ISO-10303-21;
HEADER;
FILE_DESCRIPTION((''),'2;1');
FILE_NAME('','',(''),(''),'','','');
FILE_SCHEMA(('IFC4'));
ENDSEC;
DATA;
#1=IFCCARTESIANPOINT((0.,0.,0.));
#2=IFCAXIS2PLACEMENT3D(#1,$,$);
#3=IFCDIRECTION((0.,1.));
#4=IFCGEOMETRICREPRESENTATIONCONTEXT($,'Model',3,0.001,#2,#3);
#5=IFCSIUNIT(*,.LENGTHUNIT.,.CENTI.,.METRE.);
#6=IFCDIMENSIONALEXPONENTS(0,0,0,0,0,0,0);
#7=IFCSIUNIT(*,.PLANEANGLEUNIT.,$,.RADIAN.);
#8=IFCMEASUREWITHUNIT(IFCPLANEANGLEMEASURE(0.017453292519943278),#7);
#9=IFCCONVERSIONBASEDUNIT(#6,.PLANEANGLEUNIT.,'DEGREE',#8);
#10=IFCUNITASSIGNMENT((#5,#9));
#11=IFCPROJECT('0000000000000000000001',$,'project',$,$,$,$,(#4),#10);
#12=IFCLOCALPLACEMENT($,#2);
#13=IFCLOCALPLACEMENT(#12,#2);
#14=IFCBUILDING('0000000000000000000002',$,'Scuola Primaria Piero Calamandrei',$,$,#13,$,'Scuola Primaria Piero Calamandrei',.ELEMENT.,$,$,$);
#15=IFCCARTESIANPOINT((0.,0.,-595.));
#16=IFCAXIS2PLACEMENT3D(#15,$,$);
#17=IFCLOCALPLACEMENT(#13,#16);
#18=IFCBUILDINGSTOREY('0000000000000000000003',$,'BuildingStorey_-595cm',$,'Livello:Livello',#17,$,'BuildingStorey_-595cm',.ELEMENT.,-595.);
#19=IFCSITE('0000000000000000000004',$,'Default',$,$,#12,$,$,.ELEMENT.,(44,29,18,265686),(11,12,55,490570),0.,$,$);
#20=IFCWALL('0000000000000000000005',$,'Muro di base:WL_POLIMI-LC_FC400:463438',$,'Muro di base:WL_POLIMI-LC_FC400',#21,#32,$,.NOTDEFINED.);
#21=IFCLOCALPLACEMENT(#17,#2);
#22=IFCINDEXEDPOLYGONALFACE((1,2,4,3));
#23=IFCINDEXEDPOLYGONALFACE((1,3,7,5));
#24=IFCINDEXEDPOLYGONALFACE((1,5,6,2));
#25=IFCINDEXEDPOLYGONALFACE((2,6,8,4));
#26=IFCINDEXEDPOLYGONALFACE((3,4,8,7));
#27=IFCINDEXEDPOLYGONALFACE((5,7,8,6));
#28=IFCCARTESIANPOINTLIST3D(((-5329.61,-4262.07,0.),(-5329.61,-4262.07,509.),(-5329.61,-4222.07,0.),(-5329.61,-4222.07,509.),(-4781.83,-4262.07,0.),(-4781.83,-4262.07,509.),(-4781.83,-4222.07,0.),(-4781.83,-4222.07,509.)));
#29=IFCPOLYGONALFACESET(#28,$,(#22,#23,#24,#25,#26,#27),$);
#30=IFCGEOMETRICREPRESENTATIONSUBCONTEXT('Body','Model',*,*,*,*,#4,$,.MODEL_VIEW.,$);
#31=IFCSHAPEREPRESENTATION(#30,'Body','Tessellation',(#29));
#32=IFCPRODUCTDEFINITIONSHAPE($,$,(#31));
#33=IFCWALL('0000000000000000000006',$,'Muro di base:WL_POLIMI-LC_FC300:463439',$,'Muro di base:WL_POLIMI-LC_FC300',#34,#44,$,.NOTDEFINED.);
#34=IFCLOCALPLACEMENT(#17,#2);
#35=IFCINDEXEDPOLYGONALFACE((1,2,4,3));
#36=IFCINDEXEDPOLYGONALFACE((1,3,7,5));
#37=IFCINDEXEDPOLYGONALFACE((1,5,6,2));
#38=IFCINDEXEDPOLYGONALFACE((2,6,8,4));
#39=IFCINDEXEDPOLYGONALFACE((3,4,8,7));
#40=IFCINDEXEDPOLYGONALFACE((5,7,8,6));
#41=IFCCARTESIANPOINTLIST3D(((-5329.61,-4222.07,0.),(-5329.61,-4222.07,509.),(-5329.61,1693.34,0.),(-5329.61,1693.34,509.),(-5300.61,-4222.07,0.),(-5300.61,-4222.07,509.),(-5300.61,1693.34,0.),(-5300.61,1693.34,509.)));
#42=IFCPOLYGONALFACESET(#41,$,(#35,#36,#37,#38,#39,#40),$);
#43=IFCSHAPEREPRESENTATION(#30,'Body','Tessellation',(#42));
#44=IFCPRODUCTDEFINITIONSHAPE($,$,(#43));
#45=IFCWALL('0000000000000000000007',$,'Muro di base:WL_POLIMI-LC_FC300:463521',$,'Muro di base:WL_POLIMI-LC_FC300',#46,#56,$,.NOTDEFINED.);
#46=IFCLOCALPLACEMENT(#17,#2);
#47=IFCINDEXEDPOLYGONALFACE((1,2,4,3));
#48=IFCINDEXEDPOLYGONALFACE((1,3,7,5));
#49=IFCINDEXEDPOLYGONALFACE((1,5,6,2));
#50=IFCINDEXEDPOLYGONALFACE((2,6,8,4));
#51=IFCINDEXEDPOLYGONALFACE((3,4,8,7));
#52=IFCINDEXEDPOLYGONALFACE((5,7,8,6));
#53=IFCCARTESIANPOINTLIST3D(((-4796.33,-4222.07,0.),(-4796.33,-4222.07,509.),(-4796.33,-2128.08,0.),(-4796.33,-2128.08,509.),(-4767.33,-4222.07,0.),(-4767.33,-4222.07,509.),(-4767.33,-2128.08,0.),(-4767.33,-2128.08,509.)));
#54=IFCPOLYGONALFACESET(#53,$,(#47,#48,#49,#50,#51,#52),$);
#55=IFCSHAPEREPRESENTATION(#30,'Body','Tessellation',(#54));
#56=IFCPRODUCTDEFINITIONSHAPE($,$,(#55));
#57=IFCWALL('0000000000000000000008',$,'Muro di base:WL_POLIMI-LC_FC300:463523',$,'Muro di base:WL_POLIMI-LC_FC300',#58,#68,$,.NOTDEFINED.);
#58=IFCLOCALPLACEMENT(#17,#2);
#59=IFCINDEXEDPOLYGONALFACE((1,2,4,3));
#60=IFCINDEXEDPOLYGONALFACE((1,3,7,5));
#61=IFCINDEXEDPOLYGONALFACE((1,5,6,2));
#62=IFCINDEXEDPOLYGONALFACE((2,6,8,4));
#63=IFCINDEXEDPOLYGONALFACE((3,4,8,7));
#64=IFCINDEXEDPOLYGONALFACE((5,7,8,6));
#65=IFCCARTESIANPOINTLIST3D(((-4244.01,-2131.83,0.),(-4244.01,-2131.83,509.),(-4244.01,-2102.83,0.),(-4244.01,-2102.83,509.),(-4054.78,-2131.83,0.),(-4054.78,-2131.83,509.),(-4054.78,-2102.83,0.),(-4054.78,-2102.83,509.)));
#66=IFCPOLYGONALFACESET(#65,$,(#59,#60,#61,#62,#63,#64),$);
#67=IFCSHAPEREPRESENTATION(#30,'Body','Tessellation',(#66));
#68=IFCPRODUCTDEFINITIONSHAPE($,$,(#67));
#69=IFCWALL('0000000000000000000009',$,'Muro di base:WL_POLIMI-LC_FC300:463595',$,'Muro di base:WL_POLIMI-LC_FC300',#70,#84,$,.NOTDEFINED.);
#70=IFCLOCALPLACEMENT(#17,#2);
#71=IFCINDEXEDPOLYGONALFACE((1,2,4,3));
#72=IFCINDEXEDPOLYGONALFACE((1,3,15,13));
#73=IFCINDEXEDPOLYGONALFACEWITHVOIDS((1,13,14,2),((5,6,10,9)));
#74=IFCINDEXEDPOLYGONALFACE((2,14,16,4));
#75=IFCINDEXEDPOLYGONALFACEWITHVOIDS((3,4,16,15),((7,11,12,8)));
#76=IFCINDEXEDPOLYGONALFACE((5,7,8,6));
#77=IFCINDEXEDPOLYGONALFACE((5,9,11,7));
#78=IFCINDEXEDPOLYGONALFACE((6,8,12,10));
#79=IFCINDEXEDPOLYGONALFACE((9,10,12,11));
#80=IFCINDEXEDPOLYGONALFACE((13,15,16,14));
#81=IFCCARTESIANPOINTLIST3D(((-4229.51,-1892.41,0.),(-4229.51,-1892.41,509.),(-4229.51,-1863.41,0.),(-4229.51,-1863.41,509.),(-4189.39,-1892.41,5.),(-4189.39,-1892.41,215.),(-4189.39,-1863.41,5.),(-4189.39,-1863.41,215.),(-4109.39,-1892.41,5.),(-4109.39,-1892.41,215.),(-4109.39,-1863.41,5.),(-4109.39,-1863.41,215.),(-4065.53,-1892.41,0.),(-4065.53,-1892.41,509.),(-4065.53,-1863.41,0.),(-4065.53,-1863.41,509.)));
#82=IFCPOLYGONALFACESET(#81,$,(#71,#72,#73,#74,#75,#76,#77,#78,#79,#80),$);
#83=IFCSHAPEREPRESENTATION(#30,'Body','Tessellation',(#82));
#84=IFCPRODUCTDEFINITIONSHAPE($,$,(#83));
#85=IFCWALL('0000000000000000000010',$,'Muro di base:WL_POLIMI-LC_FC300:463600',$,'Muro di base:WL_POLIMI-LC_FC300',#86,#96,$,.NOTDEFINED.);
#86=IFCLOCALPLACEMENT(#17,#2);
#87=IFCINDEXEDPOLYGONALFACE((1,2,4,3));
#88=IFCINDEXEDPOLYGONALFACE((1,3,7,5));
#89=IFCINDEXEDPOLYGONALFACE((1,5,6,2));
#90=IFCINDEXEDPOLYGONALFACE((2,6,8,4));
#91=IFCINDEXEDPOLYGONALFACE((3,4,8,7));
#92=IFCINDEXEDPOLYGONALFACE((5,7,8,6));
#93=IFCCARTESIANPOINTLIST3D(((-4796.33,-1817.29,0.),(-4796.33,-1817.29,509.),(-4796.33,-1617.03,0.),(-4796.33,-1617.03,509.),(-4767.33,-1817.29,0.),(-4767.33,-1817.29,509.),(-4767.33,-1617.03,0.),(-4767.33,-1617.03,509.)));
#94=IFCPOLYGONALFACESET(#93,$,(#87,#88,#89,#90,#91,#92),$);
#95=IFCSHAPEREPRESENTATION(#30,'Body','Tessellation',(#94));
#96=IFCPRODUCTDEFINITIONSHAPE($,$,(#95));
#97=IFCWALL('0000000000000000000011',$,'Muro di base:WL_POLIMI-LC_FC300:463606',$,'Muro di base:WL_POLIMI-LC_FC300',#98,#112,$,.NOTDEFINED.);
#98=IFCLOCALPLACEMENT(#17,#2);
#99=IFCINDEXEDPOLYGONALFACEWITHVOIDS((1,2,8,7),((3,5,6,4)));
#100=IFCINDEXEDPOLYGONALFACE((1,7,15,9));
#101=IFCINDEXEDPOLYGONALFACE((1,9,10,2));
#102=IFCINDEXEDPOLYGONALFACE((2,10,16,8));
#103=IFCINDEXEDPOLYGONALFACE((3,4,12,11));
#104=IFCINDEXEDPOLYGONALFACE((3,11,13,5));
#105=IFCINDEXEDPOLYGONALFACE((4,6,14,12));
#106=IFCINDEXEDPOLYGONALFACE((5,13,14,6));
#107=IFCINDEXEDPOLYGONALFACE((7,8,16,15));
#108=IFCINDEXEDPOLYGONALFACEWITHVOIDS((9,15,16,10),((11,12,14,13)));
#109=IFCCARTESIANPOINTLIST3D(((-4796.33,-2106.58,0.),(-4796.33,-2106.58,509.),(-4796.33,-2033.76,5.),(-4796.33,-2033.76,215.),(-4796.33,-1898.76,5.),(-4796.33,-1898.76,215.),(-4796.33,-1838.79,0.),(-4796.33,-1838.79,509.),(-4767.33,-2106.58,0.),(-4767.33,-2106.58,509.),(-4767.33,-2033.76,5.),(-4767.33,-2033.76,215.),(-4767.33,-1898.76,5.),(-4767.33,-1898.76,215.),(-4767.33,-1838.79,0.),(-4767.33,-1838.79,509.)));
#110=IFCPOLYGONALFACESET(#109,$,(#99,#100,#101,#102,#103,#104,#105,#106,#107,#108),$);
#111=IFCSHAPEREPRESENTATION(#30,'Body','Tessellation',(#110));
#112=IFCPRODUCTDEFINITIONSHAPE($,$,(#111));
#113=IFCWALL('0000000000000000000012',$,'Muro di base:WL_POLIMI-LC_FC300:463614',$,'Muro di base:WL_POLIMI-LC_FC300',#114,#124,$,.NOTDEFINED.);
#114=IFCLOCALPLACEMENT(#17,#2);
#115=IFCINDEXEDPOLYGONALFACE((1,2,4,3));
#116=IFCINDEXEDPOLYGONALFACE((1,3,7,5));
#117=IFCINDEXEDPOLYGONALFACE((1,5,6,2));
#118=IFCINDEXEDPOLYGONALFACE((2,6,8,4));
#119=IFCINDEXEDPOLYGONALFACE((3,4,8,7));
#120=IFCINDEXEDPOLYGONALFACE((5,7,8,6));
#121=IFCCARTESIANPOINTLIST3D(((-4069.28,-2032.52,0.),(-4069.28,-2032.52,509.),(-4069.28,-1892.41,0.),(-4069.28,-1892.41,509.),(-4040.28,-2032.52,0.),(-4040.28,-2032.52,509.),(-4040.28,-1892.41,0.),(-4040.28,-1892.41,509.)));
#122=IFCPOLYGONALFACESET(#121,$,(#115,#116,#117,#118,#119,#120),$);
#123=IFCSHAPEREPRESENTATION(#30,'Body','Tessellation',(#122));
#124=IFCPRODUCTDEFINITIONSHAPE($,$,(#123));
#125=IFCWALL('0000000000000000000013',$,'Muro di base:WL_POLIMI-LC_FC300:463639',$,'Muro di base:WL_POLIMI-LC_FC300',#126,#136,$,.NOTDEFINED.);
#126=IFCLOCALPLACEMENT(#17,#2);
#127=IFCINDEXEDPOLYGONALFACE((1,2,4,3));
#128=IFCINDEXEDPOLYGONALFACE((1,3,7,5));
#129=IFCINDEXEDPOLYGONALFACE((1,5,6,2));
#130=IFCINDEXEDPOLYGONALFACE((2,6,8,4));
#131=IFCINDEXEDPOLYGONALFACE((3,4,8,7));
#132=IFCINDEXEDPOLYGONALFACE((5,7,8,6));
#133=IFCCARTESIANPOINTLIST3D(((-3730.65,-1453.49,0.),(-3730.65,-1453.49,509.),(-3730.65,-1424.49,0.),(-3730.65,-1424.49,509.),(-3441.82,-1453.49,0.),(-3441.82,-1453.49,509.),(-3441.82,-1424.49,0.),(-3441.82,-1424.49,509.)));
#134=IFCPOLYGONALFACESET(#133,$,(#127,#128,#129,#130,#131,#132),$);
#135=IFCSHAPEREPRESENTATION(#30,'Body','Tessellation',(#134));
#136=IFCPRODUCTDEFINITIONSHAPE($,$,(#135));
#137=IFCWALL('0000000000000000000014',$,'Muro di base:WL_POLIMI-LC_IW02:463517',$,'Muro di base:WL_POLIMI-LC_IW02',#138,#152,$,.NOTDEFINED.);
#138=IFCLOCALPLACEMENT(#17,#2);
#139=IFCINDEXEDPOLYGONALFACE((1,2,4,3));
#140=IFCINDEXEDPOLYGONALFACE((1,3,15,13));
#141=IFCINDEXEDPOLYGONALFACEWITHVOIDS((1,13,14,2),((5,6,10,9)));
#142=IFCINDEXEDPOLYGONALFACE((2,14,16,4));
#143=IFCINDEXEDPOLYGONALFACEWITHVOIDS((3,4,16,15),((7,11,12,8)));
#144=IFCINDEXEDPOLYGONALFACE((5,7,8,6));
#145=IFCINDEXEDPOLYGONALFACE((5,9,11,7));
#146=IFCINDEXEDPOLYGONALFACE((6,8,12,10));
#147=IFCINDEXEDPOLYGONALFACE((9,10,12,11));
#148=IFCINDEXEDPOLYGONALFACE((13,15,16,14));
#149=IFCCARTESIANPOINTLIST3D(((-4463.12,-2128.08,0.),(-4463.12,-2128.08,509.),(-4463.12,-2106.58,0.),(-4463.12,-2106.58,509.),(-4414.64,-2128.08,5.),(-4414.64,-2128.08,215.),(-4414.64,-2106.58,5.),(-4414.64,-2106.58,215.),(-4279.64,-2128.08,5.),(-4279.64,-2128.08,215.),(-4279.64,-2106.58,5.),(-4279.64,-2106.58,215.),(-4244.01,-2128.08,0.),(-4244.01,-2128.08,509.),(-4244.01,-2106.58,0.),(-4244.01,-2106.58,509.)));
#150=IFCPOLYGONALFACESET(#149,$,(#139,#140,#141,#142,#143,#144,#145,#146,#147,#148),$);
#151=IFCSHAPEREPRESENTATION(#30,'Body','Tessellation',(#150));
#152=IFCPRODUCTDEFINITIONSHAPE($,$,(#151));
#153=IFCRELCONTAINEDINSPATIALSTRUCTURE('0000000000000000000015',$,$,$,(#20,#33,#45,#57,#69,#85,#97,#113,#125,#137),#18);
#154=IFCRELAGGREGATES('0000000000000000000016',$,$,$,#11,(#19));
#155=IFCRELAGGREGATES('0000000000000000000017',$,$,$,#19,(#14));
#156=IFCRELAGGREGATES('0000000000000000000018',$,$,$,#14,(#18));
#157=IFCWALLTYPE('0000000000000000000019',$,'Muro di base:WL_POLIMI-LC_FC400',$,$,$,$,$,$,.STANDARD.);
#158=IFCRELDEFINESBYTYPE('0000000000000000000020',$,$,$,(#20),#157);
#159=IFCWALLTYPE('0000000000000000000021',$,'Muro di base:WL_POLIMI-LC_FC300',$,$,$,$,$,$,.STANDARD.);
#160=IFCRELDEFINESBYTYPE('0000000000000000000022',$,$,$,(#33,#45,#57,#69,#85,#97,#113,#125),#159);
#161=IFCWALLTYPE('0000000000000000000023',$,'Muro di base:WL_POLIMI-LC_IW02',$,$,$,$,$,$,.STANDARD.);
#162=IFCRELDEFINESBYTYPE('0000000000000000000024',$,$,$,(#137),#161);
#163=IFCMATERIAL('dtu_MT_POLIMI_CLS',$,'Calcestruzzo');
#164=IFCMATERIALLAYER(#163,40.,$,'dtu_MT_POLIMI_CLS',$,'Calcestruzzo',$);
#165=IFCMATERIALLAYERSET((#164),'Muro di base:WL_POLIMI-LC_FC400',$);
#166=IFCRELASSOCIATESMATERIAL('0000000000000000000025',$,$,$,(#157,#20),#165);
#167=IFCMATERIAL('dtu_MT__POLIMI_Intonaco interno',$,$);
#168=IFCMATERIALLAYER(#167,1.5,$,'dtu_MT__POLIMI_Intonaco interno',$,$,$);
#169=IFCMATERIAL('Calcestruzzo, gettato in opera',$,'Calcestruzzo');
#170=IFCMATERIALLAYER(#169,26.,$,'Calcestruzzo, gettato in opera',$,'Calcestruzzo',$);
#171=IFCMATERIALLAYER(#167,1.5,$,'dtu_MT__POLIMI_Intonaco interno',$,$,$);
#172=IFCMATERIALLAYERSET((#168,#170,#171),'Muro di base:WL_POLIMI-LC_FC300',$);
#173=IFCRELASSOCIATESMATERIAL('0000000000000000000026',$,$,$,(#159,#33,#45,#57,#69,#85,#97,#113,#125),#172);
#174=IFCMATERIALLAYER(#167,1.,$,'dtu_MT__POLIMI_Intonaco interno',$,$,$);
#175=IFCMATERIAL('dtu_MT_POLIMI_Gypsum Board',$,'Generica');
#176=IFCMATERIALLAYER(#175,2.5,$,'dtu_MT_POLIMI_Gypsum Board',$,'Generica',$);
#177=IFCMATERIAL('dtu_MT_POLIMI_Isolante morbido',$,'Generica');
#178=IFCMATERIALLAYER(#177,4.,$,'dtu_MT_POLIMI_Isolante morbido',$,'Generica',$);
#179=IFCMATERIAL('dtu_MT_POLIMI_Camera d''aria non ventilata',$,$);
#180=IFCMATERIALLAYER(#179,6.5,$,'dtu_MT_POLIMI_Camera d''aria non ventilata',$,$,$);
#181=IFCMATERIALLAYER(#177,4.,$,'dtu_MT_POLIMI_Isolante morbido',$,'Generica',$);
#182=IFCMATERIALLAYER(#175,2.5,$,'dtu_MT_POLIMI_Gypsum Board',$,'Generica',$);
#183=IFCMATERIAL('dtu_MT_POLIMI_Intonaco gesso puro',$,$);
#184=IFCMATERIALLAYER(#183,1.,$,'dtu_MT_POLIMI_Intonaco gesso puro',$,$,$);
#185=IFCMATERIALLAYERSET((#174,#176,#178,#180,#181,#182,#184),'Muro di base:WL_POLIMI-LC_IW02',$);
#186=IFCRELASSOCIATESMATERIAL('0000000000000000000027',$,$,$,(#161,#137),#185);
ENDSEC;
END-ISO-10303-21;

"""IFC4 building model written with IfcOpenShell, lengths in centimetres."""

from ifc_helpers import new_model, entity, si_unit, converted_unit, direction, frame, frame_2d, origin, place, context, subcontext, project, spatial, polyline, rectangle, extrude, clip, bounded_halfspace, material, layer, layer_set, layer_usage, type_object, element, save


model = new_model("IFC4")

# Units and contexts
model_context = context("Model", 3, precision=0.001, world=origin(), true_north=direction((0.0, 1.0)))
body_context = subcontext(model_context, "Body", "Model", "MODEL_VIEW")
ifc_project = project(units=[si_unit("LENGTHUNIT", "METRE", prefix="CENTI"), converted_unit("PLANEANGLEUNIT", "DEGREE", entity("IfcPlaneAngleMeasure", 0.017453292519943278), si_unit("PLANEANGLEUNIT", "RADIAN"), dimensions=[0, 0, 0, 0, 0, 0, 0])], contexts=[model_context])

# Site, building, storey
site_placement = place(None, origin())
site = spatial("IfcSite", under=ifc_project, at=site_placement, Name="Default", CompositionType="ELEMENT", RefLatitude=(44, 29, 18, 265686), RefLongitude=(11, 12, 55, 490570), RefElevation=0.0)
building_placement = place(site_placement, origin())
building = spatial("IfcBuilding", under=site, at=building_placement, Name="Scuola Primaria Piero Calamandrei", LongName="Scuola Primaria Piero Calamandrei", CompositionType="ELEMENT")
storey_placement = place(building_placement, frame((0.0, 0.0, -595.0)))
storey = spatial("IfcBuildingStorey", under=building, at=storey_placement, Name="BuildingStorey_-595cm", ObjectType="Livello:Livello", LongName="BuildingStorey_-595cm", CompositionType="ELEMENT", Elevation=-595.0)

# Walls
ifc_material_1 = material(Name="dtu_MT_POLIMI_CLS", Category="Calcestruzzo")
ifc_layer_1 = layer(ifc_material_1, 40.0, Name="dtu_MT_POLIMI_CLS", Category="Calcestruzzo")
ifc_layer_set_1 = layer_set([ifc_layer_1], Name="Muro di base:WL_POLIMI-LC_FC400")
ifc_layer_usage_1 = layer_usage(ifc_layer_set_1, "AXIS2", "NEGATIVE", 20.0)
wall_type_1 = type_object("IfcWallType", Name="Muro di base:WL_POLIMI-LC_FC400", PredefinedType="STANDARD", material=ifc_layer_set_1)
wall_1_placement = place(storey_placement, frame((-4781.83, -4242.07, 0.0), z_axis=(0.0, 0.0, 1.0), x_axis=(-1.0, 0.0, 0.0)))
element("IfcWall", 1, at=wall_1_placement, inside=storey, type_object=wall_type_1, material=ifc_layer_usage_1, Name="Muro di base:WL_POLIMI-LC_FC400:463438", ObjectType="Muro di base:WL_POLIMI-LC_FC400", PredefinedType="NOTDEFINED", context=body_context, shape_type="Clipping", body=[
    clip(extrude(rectangle(XDim=547.78, YDim=40.0, at=frame_2d((273.89, 0.0), x_axis=(-1.0, 0.0))), origin(), (0.0, 0.0, 1.0), 509.0), bounded_halfspace(frame((0.0, -20.0, 509.0), z_axis=(0.0, 0.0, 1.0), x_axis=(-1.0, 0.0, 0.0)), False, frame((0.0, -20.0, 509.0)), polyline([(0.0, 0.0), (14.5, 0.0), (518.78, 0.0), (547.78, 0.0), (547.78, 40.0), (0.0, 40.0), (0.0, 0.0)]))),
])
ifc_material_2 = material(Name="dtu_MT__POLIMI_Intonaco interno")
ifc_layer_2 = layer(ifc_material_2, 1.5, Name="dtu_MT__POLIMI_Intonaco interno")
ifc_material_3 = material(Name="Calcestruzzo, gettato in opera", Category="Calcestruzzo")
ifc_layer_3 = layer(ifc_material_3, 26.0, Name="Calcestruzzo, gettato in opera", Category="Calcestruzzo")
ifc_layer_4 = layer(ifc_material_2, 1.5, Name="dtu_MT__POLIMI_Intonaco interno")
ifc_layer_set_2 = layer_set([ifc_layer_2, ifc_layer_3, ifc_layer_4], Name="Muro di base:WL_POLIMI-LC_FC300")
ifc_layer_usage_2 = layer_usage(ifc_layer_set_2, "AXIS2", "NEGATIVE", 14.5)
wall_type_2 = type_object("IfcWallType", Name="Muro di base:WL_POLIMI-LC_FC300", PredefinedType="STANDARD", material=ifc_layer_set_2)
wall_2_placement = place(storey_placement, frame((-5315.11, -4222.07, 0.0), z_axis=(0.0, 0.0, 1.0), x_axis=(0.0, 1.0, 0.0)))
element("IfcWall", 2, at=wall_2_placement, inside=storey, type_object=wall_type_2, material=ifc_layer_usage_2, Name="Muro di base:WL_POLIMI-LC_FC300:463439", ObjectType="Muro di base:WL_POLIMI-LC_FC300", PredefinedType="NOTDEFINED", context=body_context, shape_type="Clipping", body=[
    clip(extrude(rectangle(XDim=5915.41, YDim=29.0, at=frame_2d((2957.7, 0.0), x_axis=(-1.0, 0.0))), origin(), (0.0, 0.0, 1.0), 509.0), bounded_halfspace(frame((0.0, -14.5, 509.0), z_axis=(0.0, 0.0, 1.0), x_axis=(0.0, -1.0, 0.0)), False, frame((0.0, -14.5, 509.0)), polyline([(0.0, 0.0), (5900.91, 0.0), (5915.41, 0.0), (5915.41, 29.0), (0.0, 29.0), (0.0, 0.0)]))),
])
ifc_layer_usage_3 = layer_usage(ifc_layer_set_2, "AXIS2", "NEGATIVE", 14.5)
wall_3_placement = place(storey_placement, frame((-4781.83, -4222.07, 0.0), z_axis=(0.0, 0.0, 1.0), x_axis=(0.0, 1.0, 0.0)))
element("IfcWall", 3, at=wall_3_placement, inside=storey, type_object=wall_type_2, material=ifc_layer_usage_3, Name="Muro di base:WL_POLIMI-LC_FC300:463521", ObjectType="Muro di base:WL_POLIMI-LC_FC300", PredefinedType="NOTDEFINED", context=body_context, shape_type="SweptSolid", body=[
    extrude(rectangle(XDim=2093.99, YDim=29.0, at=frame_2d((1047.0, 0.0), x_axis=(-1.0, 0.0))), origin(), (0.0, 0.0, 1.0), 509.0),
])
ifc_layer_usage_4 = layer_usage(ifc_layer_set_2, "AXIS2", "NEGATIVE", 14.5)
wall_4_placement = place(storey_placement, frame((-4244.01, -2117.33, 0.0)))
element("IfcWall", 4, at=wall_4_placement, inside=storey, type_object=wall_type_2, material=ifc_layer_usage_4, Name="Muro di base:WL_POLIMI-LC_FC300:463523", ObjectType="Muro di base:WL_POLIMI-LC_FC300", PredefinedType="NOTDEFINED", context=body_context, shape_type="SweptSolid", body=[
    extrude(rectangle(XDim=189.23, YDim=29.0, at=frame_2d((94.62, 0.0), x_axis=(-1.0, 0.0))), origin(), (0.0, 0.0, 1.0), 509.0),
])

# Wall, opening
ifc_layer_usage_5 = layer_usage(ifc_layer_set_2, "AXIS2", "NEGATIVE", 14.5)
wall_5_placement = place(storey_placement, frame((-4065.53, -1877.91, 0.0), z_axis=(0.0, 0.0, 1.0), x_axis=(-1.0, 0.0, 0.0)))
wall_5 = element("IfcWall", 5, at=wall_5_placement, inside=storey, type_object=wall_type_2, material=ifc_layer_usage_5, Name="Muro di base:WL_POLIMI-LC_FC300:463595", ObjectType="Muro di base:WL_POLIMI-LC_FC300", PredefinedType="NOTDEFINED", context=body_context, shape_type="SweptSolid", body=[
    extrude(rectangle(XDim=163.98, YDim=29.0, at=frame_2d((81.99, 0.0), x_axis=(-1.0, 0.0))), origin(), (0.0, 0.0, 1.0), 509.0),
])
opening_1_placement = place(wall_5_placement, frame((43.87, -14.5, 5.0)))
element("IfcOpeningElement", 6, at=opening_1_placement, cuts=wall_5, PredefinedType="OPENING", context=body_context, shape_type="SweptSolid", body=[
    extrude(rectangle(XDim=210.0, YDim=80.0, at=frame_2d((105.0, 40.0), x_axis=(1.0, 0.0))), frame((0.0, 0.0, 0.0), z_axis=(0.0, 1.0, 0.0), x_axis=(0.0, 0.0, 1.0)), (0.0, 0.0, 1.0), 29.0),
])

# Wall
ifc_layer_usage_6 = layer_usage(ifc_layer_set_2, "AXIS2", "NEGATIVE", 14.5)
wall_6_placement = place(storey_placement, frame((-4781.83, -1817.29, 0.0), z_axis=(0.0, 0.0, 1.0), x_axis=(0.0, 1.0, 0.0)))
element("IfcWall", 7, at=wall_6_placement, inside=storey, type_object=wall_type_2, material=ifc_layer_usage_6, Name="Muro di base:WL_POLIMI-LC_FC300:463600", ObjectType="Muro di base:WL_POLIMI-LC_FC300", PredefinedType="NOTDEFINED", context=body_context, shape_type="SweptSolid", body=[
    extrude(rectangle(XDim=200.26, YDim=29.0, at=frame_2d((100.13, 0.0), x_axis=(-1.0, 0.0))), origin(), (0.0, 0.0, 1.0), 509.0),
])

# Wall, opening
ifc_layer_usage_7 = layer_usage(ifc_layer_set_2, "AXIS2", "NEGATIVE", 14.5)
wall_7_placement = place(storey_placement, frame((-4781.83, -2106.58, 0.0), z_axis=(0.0, 0.0, 1.0), x_axis=(0.0, 1.0, 0.0)))
wall_7 = element("IfcWall", 8, at=wall_7_placement, inside=storey, type_object=wall_type_2, material=ifc_layer_usage_7, Name="Muro di base:WL_POLIMI-LC_FC300:463606", ObjectType="Muro di base:WL_POLIMI-LC_FC300", PredefinedType="NOTDEFINED", context=body_context, shape_type="SweptSolid", body=[
    extrude(rectangle(XDim=267.79, YDim=29.0, at=frame_2d((133.9, 0.0), x_axis=(-1.0, 0.0))), origin(), (0.0, 0.0, 1.0), 509.0),
])
opening_2_placement = place(wall_7_placement, frame((72.82, -14.5, 5.0)))
element("IfcOpeningElement", 9, at=opening_2_placement, cuts=wall_7, PredefinedType="OPENING", context=body_context, shape_type="SweptSolid", body=[
    extrude(rectangle(XDim=210.0, YDim=135.0, at=frame_2d((105.0, 67.5), x_axis=(-1.0, 0.0))), frame((0.0, 0.0, 0.0), z_axis=(0.0, 1.0, 0.0), x_axis=(0.0, 0.0, 1.0)), (0.0, 0.0, 1.0), 29.0),
])

# Walls
ifc_layer_usage_8 = layer_usage(ifc_layer_set_2, "AXIS2", "NEGATIVE", 14.5)
wall_8_placement = place(storey_placement, frame((-4054.78, -1892.41, 0.0), z_axis=(0.0, 0.0, 1.0), x_axis=(0.0, -1.0, 0.0)))
element("IfcWall", 10, at=wall_8_placement, inside=storey, type_object=wall_type_2, material=ifc_layer_usage_8, Name="Muro di base:WL_POLIMI-LC_FC300:463614", ObjectType="Muro di base:WL_POLIMI-LC_FC300", PredefinedType="NOTDEFINED", context=body_context, shape_type="SweptSolid", body=[
    extrude(rectangle(XDim=140.11, YDim=29.0, at=frame_2d((70.05, 0.0), x_axis=(-1.0, 0.0))), origin(), (0.0, 0.0, 1.0), 509.0),
])
ifc_layer_usage_9 = layer_usage(ifc_layer_set_2, "AXIS2", "NEGATIVE", 14.5)
wall_9_placement = place(storey_placement, frame((-3730.65, -1438.99, 0.0)))
element("IfcWall", 11, at=wall_9_placement, inside=storey, type_object=wall_type_2, material=ifc_layer_usage_9, Name="Muro di base:WL_POLIMI-LC_FC300:463639", ObjectType="Muro di base:WL_POLIMI-LC_FC300", PredefinedType="NOTDEFINED", context=body_context, shape_type="SweptSolid", body=[
    extrude(rectangle(XDim=288.83, YDim=29.0, at=frame_2d((144.41, 0.0), x_axis=(-1.0, 0.0))), origin(), (0.0, 0.0, 1.0), 509.0),
])

# Wall, opening
ifc_layer_5 = layer(ifc_material_2, 1.0, Name="dtu_MT__POLIMI_Intonaco interno")
ifc_material_4 = material(Name="dtu_MT_POLIMI_Gypsum Board", Category="Generica")
ifc_layer_6 = layer(ifc_material_4, 2.5, Name="dtu_MT_POLIMI_Gypsum Board", Category="Generica")
ifc_material_5 = material(Name="dtu_MT_POLIMI_Isolante morbido", Category="Generica")
ifc_layer_7 = layer(ifc_material_5, 4.0, Name="dtu_MT_POLIMI_Isolante morbido", Category="Generica")
ifc_material_6 = material(Name="dtu_MT_POLIMI_Camera d'aria non ventilata")
ifc_layer_8 = layer(ifc_material_6, 6.5, Name="dtu_MT_POLIMI_Camera d'aria non ventilata")
ifc_layer_9 = layer(ifc_material_5, 4.0, Name="dtu_MT_POLIMI_Isolante morbido", Category="Generica")
ifc_layer_10 = layer(ifc_material_4, 2.5, Name="dtu_MT_POLIMI_Gypsum Board", Category="Generica")
ifc_material_7 = material(Name="dtu_MT_POLIMI_Intonaco gesso puro")
ifc_layer_11 = layer(ifc_material_7, 1.0, Name="dtu_MT_POLIMI_Intonaco gesso puro")
ifc_layer_set_3 = layer_set([ifc_layer_5, ifc_layer_6, ifc_layer_7, ifc_layer_8, ifc_layer_9, ifc_layer_10, ifc_layer_11], Name="Muro di base:WL_POLIMI-LC_IW02")
ifc_layer_usage_10 = layer_usage(ifc_layer_set_3, "AXIS2", "NEGATIVE", 10.75)
wall_type_3 = type_object("IfcWallType", Name="Muro di base:WL_POLIMI-LC_IW02", PredefinedType="STANDARD", material=ifc_layer_set_3)
wall_10_placement = place(storey_placement, frame((-4463.12, -2117.33, 0.0)))
wall_10 = element("IfcWall", 12, at=wall_10_placement, inside=storey, type_object=wall_type_3, material=ifc_layer_usage_10, Name="Muro di base:WL_POLIMI-LC_IW02:463517", ObjectType="Muro di base:WL_POLIMI-LC_IW02", PredefinedType="NOTDEFINED", context=body_context, shape_type="SweptSolid", body=[
    extrude(rectangle(XDim=219.11, YDim=21.5, at=frame_2d((109.56, 0.0), x_axis=(-1.0, 0.0))), origin(), (0.0, 0.0, 1.0), 509.0),
])
opening_3_placement = place(wall_10_placement, frame((48.48, -10.75, 5.0)))
element("IfcOpeningElement", 13, at=opening_3_placement, cuts=wall_10, PredefinedType="OPENING", context=body_context, shape_type="SweptSolid", body=[
    extrude(rectangle(XDim=210.0, YDim=135.0, at=frame_2d((105.0, 67.5), x_axis=(-1.0, 0.0))), frame((0.0, 0.0, 0.0), z_axis=(0.0, 1.0, 0.0), x_axis=(0.0, 0.0, 1.0)), (0.0, 0.0, 1.0), 21.5),
])

save(model, "model.ifc")
